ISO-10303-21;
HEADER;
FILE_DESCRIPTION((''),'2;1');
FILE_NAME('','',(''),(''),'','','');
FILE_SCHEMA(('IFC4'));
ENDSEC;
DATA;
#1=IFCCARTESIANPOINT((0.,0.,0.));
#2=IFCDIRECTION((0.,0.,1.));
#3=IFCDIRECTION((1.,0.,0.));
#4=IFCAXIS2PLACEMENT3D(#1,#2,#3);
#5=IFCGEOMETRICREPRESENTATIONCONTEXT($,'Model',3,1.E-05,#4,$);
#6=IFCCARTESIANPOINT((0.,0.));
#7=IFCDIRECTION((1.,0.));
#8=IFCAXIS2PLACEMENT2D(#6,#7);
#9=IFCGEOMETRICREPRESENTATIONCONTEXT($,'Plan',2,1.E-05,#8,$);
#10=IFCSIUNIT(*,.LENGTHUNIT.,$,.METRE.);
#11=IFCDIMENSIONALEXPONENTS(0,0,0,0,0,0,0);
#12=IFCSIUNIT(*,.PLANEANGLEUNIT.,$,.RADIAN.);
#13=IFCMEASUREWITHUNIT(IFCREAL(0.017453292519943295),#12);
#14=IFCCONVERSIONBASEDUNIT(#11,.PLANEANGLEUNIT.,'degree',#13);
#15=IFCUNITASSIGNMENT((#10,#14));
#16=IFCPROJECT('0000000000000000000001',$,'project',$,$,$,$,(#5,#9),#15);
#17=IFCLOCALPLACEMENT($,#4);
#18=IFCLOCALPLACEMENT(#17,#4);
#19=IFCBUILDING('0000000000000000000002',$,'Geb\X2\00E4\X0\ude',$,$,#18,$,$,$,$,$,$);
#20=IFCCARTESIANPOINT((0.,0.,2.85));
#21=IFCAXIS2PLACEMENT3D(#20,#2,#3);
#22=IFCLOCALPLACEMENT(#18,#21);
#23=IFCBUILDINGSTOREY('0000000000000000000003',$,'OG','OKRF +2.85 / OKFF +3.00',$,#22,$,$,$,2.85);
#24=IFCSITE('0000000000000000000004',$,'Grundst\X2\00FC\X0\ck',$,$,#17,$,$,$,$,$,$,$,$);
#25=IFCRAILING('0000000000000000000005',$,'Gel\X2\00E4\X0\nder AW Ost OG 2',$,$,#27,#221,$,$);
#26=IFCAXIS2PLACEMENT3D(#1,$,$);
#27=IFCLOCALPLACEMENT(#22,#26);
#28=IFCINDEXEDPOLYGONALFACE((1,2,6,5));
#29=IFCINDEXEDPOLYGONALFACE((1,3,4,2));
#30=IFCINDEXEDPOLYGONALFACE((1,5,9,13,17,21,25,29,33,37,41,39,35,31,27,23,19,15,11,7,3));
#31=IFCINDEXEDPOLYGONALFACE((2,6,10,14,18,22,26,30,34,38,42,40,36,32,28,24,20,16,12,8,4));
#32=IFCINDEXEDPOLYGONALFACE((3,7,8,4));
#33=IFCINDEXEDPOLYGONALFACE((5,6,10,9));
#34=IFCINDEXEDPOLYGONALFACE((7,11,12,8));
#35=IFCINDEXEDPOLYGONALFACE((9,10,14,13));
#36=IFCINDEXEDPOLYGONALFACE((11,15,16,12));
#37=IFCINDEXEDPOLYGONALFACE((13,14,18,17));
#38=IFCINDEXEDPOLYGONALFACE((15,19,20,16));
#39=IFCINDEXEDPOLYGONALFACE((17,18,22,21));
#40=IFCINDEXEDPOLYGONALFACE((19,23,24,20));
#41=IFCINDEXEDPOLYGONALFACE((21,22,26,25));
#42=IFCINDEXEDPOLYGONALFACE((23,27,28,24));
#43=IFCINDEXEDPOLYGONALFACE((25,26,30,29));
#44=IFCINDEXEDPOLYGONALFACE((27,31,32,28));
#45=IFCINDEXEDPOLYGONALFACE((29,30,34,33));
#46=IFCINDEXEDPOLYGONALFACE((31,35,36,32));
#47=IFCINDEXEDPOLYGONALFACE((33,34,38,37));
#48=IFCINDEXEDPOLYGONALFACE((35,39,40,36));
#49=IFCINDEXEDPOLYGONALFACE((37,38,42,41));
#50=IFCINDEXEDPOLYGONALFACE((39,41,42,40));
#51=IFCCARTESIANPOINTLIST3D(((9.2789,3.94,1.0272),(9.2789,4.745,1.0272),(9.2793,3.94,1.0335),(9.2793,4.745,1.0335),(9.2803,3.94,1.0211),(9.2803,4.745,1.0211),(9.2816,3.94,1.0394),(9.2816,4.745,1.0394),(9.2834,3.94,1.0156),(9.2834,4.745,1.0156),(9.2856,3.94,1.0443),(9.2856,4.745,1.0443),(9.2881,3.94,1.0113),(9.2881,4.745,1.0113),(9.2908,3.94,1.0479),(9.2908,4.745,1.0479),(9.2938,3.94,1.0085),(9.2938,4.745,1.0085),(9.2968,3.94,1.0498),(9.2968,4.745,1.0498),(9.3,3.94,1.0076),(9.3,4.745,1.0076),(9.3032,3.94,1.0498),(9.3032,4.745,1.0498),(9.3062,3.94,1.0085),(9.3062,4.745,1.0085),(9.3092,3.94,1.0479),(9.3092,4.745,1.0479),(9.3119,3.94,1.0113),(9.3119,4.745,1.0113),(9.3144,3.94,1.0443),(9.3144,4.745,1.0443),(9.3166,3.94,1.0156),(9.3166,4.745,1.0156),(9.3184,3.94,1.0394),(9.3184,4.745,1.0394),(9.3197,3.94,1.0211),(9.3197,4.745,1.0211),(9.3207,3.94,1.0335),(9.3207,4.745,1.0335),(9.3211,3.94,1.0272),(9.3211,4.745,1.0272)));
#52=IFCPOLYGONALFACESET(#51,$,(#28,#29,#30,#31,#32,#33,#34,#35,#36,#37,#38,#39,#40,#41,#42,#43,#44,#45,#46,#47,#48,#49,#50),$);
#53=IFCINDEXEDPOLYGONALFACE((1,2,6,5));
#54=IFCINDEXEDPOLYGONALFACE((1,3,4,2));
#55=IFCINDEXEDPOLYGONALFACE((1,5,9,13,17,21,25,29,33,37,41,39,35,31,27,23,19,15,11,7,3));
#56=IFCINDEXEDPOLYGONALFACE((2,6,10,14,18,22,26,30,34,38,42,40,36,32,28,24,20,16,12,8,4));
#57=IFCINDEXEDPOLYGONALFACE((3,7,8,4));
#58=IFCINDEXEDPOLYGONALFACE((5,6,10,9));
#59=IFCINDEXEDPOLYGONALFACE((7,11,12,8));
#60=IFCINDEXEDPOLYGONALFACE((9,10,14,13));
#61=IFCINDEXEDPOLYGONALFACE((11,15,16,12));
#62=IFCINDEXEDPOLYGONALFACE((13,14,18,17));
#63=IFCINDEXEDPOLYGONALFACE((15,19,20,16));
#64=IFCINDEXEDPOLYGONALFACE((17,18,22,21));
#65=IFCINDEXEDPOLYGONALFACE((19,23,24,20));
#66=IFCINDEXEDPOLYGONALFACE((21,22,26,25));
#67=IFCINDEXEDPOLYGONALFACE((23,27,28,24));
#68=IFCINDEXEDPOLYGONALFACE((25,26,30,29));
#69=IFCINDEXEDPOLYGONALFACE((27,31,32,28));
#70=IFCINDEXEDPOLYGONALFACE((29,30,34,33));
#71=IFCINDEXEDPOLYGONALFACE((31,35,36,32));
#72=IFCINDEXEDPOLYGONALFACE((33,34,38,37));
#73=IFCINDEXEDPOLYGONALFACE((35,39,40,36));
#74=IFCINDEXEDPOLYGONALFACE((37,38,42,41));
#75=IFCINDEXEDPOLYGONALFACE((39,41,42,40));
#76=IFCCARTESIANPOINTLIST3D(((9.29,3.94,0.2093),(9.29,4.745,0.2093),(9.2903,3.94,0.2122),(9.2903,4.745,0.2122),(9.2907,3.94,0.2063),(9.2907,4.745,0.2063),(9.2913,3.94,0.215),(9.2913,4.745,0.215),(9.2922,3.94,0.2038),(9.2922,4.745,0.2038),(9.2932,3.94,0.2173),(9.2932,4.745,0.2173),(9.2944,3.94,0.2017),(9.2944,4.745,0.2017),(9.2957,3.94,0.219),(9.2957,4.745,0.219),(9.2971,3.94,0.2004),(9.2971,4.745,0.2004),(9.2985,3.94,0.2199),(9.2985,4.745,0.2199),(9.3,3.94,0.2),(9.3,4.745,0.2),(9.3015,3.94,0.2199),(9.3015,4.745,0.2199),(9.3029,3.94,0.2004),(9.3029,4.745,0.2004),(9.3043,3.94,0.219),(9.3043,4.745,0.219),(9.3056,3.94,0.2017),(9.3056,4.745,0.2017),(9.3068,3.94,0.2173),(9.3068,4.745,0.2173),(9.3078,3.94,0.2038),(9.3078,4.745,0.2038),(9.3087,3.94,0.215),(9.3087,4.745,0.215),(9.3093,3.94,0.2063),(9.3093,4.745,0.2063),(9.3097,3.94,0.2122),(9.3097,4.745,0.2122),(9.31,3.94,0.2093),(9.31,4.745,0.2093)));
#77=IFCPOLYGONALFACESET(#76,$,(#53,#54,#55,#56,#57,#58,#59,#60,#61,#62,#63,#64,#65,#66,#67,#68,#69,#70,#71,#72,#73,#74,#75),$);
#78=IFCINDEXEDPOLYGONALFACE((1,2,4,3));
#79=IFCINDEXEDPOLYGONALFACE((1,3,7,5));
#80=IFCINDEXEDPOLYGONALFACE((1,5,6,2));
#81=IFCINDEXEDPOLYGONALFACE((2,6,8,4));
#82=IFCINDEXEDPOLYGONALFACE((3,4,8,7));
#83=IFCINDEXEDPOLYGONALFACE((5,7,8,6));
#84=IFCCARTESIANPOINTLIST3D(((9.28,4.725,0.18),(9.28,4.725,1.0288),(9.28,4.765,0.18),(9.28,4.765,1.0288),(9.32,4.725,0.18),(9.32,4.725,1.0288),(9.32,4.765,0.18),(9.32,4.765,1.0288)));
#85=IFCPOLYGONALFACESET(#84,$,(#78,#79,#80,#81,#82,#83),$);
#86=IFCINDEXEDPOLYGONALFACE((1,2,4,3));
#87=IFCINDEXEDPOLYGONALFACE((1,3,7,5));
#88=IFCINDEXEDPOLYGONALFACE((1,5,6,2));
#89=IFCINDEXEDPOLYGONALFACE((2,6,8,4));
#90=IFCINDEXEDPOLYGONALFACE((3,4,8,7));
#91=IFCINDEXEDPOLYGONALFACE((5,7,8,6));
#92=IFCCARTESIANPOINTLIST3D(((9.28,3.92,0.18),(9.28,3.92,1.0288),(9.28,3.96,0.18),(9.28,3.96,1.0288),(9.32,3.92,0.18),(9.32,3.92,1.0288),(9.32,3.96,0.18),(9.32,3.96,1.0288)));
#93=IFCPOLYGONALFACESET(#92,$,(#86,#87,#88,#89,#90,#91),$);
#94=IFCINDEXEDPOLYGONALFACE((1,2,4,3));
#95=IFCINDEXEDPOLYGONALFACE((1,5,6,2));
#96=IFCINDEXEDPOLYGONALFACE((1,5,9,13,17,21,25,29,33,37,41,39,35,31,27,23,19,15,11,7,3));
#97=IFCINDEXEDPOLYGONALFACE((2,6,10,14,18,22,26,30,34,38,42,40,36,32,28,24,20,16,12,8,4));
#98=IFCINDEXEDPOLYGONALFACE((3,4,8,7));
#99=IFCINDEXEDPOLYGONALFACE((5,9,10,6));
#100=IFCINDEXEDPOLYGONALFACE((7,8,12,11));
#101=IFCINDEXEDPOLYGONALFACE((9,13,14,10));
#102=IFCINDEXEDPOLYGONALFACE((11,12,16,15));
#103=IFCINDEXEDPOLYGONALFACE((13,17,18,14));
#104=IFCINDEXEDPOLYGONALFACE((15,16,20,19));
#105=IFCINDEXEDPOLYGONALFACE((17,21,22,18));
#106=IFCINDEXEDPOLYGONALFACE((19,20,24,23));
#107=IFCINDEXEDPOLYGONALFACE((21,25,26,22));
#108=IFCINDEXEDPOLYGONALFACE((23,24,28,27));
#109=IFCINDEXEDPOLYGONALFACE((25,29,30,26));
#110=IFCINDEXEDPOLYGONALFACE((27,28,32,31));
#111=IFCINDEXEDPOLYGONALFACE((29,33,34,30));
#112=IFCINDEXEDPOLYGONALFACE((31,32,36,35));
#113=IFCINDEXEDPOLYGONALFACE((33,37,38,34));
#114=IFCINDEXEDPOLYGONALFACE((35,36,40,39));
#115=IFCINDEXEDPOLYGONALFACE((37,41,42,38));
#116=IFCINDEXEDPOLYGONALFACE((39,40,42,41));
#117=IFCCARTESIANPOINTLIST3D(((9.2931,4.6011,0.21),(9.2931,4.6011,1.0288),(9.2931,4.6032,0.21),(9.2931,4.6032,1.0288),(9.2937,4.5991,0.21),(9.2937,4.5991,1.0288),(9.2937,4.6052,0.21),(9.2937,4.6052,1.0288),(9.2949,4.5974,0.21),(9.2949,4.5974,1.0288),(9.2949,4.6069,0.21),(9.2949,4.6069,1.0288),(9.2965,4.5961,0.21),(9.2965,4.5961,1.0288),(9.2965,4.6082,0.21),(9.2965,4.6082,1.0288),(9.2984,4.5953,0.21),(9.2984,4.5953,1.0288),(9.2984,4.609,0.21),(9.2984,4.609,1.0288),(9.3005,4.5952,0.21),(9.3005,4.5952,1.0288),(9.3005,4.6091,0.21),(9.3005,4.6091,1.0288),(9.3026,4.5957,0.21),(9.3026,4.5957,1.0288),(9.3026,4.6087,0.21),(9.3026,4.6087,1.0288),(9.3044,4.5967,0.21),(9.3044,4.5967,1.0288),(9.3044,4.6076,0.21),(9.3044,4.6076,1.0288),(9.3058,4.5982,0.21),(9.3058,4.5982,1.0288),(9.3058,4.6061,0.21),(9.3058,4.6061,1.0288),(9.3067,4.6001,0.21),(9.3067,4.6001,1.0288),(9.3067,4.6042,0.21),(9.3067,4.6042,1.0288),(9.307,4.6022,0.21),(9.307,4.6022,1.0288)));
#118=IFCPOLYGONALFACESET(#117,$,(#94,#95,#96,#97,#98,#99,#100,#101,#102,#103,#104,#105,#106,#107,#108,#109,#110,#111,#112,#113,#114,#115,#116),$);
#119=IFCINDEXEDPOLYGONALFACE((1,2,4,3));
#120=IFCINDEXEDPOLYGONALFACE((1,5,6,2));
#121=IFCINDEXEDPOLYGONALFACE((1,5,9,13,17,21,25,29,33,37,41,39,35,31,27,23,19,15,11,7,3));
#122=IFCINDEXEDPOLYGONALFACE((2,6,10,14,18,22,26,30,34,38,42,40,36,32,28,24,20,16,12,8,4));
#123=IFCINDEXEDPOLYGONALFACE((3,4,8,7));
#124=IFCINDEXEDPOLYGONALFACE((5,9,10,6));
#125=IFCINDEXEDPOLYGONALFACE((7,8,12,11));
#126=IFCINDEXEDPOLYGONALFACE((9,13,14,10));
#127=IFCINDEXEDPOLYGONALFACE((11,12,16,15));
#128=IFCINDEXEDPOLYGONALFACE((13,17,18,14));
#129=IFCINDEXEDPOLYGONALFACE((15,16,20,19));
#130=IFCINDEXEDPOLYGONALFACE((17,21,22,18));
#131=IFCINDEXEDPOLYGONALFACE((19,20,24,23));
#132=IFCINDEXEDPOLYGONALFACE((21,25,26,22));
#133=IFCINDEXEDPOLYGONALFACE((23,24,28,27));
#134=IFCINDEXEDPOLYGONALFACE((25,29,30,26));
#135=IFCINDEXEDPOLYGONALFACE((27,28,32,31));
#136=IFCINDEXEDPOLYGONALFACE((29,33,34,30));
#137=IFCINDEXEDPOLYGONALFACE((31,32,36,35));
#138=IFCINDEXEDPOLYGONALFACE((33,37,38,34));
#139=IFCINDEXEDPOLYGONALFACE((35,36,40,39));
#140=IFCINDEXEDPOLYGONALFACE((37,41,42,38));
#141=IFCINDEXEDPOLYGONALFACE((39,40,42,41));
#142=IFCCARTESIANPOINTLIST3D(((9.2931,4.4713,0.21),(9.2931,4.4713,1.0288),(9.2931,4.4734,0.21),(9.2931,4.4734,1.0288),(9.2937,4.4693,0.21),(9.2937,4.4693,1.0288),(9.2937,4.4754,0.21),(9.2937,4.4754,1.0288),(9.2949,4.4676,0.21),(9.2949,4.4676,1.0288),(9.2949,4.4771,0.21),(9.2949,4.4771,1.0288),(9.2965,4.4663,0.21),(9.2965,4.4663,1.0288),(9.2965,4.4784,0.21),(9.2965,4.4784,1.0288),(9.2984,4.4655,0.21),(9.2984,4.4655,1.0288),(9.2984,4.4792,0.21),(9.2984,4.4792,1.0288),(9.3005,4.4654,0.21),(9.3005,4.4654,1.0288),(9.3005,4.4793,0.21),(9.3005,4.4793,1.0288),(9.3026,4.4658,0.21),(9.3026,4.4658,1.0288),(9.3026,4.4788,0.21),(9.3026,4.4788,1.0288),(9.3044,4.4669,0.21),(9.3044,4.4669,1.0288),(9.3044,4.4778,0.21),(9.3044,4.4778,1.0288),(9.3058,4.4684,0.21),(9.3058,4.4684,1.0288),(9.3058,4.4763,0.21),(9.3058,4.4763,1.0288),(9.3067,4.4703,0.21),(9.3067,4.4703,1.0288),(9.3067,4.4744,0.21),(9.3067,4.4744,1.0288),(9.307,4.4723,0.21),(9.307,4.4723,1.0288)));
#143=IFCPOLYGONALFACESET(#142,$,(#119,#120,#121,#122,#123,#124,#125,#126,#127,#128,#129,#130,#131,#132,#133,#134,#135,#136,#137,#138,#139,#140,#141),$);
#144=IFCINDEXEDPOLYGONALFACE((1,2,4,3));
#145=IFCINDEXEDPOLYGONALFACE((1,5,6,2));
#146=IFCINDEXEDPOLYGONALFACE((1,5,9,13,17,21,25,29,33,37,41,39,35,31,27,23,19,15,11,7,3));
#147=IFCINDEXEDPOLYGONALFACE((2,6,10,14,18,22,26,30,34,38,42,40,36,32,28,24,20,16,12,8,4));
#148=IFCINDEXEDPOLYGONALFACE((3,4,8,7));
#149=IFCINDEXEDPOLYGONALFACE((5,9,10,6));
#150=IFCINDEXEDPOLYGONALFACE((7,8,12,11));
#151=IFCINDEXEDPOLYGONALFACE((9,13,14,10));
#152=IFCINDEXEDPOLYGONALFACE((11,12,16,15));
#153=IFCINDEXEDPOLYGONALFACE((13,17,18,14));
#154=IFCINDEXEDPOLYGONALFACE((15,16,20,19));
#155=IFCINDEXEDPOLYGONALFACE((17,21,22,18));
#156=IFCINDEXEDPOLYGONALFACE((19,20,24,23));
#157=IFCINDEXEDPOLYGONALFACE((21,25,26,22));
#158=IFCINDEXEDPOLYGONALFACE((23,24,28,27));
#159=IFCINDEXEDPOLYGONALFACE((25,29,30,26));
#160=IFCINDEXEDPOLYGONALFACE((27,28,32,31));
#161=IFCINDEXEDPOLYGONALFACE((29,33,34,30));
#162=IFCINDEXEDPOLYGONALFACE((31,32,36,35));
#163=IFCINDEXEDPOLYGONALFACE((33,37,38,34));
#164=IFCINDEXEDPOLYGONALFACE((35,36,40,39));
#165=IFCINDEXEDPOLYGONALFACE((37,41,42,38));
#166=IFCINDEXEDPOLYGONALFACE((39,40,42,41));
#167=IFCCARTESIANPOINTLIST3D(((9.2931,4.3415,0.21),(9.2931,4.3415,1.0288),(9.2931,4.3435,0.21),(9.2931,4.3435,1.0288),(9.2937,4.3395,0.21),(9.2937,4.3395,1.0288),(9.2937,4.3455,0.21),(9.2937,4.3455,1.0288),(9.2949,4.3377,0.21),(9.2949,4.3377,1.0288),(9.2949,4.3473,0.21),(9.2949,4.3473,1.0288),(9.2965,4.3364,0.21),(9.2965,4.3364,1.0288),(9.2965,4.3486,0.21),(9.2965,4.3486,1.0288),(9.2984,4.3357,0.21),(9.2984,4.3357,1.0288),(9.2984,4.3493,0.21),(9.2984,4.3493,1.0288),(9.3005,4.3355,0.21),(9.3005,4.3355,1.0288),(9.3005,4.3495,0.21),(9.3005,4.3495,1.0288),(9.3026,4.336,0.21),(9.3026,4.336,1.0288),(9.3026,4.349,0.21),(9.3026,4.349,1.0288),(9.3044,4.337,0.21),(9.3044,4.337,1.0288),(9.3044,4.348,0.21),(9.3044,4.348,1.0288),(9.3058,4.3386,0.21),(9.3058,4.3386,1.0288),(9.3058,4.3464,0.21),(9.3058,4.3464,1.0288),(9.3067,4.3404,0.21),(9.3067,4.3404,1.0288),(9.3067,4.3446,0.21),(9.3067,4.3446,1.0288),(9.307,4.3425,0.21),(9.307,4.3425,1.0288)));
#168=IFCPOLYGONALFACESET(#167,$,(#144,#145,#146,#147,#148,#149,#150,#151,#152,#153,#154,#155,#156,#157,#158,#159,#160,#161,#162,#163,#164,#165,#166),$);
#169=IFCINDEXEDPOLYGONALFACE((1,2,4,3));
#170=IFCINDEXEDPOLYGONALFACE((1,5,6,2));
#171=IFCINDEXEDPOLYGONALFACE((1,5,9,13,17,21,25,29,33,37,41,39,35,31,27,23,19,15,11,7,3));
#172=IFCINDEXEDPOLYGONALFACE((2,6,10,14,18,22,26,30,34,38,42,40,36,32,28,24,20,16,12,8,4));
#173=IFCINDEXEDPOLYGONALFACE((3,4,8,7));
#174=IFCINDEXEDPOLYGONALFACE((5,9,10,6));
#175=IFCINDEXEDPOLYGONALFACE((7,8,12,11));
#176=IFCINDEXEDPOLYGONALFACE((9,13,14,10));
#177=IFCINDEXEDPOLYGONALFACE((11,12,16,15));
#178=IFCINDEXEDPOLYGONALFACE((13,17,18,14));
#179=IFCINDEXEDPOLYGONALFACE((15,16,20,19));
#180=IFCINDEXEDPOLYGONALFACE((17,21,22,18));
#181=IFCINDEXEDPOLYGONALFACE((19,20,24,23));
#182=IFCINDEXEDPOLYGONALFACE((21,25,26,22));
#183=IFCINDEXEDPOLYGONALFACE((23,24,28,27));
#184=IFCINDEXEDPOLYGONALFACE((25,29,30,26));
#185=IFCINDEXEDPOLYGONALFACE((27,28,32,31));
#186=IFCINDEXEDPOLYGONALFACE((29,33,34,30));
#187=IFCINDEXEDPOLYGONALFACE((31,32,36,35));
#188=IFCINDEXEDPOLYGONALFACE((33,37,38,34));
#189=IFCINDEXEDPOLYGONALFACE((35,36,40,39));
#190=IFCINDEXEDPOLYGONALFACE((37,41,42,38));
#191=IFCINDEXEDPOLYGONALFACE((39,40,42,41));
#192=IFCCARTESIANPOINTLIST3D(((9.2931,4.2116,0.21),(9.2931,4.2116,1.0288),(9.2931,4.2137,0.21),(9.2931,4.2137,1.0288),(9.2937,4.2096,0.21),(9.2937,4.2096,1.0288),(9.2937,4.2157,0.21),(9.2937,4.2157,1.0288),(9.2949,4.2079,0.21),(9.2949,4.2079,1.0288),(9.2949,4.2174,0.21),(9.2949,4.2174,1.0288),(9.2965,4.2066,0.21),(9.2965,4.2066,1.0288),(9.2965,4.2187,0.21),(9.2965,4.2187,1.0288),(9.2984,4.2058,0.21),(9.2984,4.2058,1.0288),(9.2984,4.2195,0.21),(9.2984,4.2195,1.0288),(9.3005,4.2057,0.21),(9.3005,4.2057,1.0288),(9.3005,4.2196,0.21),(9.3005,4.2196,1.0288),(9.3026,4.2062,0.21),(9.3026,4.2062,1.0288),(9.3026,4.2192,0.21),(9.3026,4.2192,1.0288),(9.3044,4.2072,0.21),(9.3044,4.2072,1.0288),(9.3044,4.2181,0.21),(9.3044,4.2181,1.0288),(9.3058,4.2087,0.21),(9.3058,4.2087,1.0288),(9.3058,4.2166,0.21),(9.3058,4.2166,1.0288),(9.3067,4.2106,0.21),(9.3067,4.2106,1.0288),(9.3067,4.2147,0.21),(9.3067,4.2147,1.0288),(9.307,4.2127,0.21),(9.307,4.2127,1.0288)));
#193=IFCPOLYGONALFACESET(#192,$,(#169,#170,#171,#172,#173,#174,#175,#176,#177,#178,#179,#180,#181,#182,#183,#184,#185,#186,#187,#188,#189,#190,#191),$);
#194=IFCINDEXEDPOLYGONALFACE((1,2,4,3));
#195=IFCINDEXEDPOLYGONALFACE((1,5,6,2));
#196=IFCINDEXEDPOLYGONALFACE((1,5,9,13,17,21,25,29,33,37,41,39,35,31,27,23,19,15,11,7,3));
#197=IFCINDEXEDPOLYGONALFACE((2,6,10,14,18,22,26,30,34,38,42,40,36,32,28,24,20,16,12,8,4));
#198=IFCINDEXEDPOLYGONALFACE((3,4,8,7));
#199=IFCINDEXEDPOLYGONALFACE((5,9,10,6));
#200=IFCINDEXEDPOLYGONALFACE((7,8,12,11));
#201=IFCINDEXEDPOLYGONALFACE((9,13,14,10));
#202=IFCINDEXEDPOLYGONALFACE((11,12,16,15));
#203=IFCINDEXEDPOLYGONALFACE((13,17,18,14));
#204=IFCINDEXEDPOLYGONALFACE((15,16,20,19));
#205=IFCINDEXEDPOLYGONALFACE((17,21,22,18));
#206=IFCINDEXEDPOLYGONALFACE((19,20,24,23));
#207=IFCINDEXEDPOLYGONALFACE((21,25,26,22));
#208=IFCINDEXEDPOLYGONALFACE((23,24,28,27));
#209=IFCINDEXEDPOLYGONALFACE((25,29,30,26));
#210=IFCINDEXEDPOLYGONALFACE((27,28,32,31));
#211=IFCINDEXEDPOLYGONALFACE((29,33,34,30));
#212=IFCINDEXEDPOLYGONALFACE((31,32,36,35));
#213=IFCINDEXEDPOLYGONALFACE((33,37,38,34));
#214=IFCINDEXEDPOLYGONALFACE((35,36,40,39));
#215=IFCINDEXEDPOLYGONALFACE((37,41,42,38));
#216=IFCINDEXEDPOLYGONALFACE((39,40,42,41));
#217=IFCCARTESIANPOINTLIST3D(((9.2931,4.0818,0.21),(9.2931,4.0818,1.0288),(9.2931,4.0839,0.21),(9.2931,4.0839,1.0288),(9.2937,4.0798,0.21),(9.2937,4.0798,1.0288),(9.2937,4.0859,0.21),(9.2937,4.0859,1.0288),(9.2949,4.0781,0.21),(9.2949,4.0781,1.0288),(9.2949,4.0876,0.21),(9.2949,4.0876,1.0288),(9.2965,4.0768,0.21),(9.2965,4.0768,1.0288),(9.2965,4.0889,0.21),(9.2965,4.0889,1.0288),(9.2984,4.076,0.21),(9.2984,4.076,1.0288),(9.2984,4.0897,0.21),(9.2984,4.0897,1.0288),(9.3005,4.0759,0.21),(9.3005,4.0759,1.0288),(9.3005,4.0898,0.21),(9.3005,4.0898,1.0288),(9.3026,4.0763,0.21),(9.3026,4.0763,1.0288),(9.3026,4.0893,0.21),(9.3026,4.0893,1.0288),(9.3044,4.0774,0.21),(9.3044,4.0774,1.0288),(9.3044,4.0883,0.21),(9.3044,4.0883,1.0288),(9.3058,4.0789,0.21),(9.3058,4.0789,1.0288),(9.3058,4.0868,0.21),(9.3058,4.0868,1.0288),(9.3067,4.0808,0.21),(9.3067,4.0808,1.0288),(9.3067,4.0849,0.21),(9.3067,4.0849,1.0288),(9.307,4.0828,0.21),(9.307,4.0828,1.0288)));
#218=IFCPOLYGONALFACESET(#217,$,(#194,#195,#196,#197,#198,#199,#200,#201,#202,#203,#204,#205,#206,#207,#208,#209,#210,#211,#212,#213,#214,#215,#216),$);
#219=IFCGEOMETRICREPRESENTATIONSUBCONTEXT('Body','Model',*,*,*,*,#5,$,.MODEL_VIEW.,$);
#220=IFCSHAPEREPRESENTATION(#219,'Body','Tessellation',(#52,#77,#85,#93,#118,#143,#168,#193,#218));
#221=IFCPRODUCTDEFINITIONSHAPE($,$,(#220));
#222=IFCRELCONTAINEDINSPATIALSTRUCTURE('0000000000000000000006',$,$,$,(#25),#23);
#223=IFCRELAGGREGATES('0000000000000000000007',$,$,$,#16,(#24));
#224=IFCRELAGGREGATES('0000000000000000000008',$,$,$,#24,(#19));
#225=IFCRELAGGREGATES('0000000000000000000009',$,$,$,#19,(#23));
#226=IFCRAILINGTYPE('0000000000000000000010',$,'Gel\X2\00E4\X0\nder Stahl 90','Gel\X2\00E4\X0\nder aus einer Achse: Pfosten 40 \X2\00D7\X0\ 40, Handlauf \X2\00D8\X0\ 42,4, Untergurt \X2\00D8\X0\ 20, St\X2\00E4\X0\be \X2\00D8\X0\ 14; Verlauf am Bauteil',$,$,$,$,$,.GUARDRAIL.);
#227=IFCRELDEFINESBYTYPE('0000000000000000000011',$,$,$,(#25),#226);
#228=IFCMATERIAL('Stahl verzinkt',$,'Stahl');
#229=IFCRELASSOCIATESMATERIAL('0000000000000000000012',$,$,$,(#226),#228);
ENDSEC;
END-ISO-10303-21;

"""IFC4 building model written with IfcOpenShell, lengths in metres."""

from ifc_helpers import new_model, entity, si_unit, converted_unit, frame, origin_with_axes, origin_2d_with_axis, place, context, subcontext, project, spatial, polyline, outline, extrude, material, type_object, element, save


model = new_model("IFC4")

# Units and contexts
model_context = context("Model", 3, precision=1e-05, world=origin_with_axes())
plan_context = context("Plan", 2, precision=1e-05, world=origin_2d_with_axis())
body_context = subcontext(model_context, "Body", "Model", "MODEL_VIEW")
ifc_project = project(units=[si_unit("LENGTHUNIT", "METRE"), converted_unit("PLANEANGLEUNIT", "degree", entity("IfcReal", 0.017453292519943295), si_unit("PLANEANGLEUNIT", "RADIAN"), dimensions=[0, 0, 0, 0, 0, 0, 0])], contexts=[model_context, plan_context])

# Site, building, storey
site_placement = place(None, origin_with_axes())
site = spatial("IfcSite", under=ifc_project, at=site_placement, Name="Grundstück")
building_placement = place(site_placement, origin_with_axes())
building = spatial("IfcBuilding", under=site, at=building_placement, Name="Gebäude")
storey_placement = place(building_placement, frame((0.0, 0.0, 2.85), z_axis=(0.0, 0.0, 1.0), x_axis=(1.0, 0.0, 0.0)))
storey = spatial("IfcBuildingStorey", under=building, at=storey_placement, Name="OG", Description="OKRF +2.85 / OKFF +3.00", Elevation=2.85)

# Railing
ifc_material_1 = material(Name="Stahl verzinkt", Category="Stahl")
railing_type = type_object("IfcRailingType", Name="Geländer Stahl 90", Description="Geländer aus einer Achse: Pfosten 40 × 40, Handlauf Ø 42,4, Untergurt Ø 20, Stäbe Ø 14; Verlauf am Bauteil", PredefinedType="GUARDRAIL", material=ifc_material_1)
railing_1_placement = place(storey_placement, frame((0.0, 0.0, -2.85), z_axis=(0.0, 0.0, 1.0), x_axis=(1.0, 0.0, 0.0)))
element("IfcRailing", 1, at=railing_1_placement, inside=storey, type_object=railing_type, Name="Geländer AW Ost OG 2", context=body_context, shape_type="SolidModel", body=[
    entity("IfcSweptDiskSolid", entity("IfcPolyline", [entity("IfcCartesianPoint", [9.3, 4.745, 3.8788]), entity("IfcCartesianPoint", [9.3, 3.94, 3.8788])]), 0.0212),
    entity("IfcSweptDiskSolid", entity("IfcPolyline", [entity("IfcCartesianPoint", [9.3, 4.745, 3.06]), entity("IfcCartesianPoint", [9.3, 3.94, 3.06])]), 0.01),
    extrude(outline(polyline([(9.28, 4.765), (9.28, 4.725), (9.32, 4.725), (9.32, 4.765), (9.28, 4.765)])), frame((0.0, 0.0, 3.03), z_axis=(0.0, 0.0, 1.0), x_axis=(1.0, 0.0, 0.0)), (0.0, 0.0, 1.0), 0.8488),
    extrude(outline(polyline([(9.28, 3.96), (9.28, 3.92), (9.32, 3.92), (9.32, 3.96), (9.28, 3.96)])), frame((0.0, 0.0, 3.03), z_axis=(0.0, 0.0, 1.0), x_axis=(1.0, 0.0, 0.0)), (0.0, 0.0, 1.0), 0.8488),
    entity("IfcSweptDiskSolid", entity("IfcPolyline", [entity("IfcCartesianPoint", [9.3, 4.6022, 3.06]), entity("IfcCartesianPoint", [9.3, 4.6022, 3.8788])]), 0.007),
    entity("IfcSweptDiskSolid", entity("IfcPolyline", [entity("IfcCartesianPoint", [9.3, 4.4723, 3.06]), entity("IfcCartesianPoint", [9.3, 4.4723, 3.8788])]), 0.007),
    entity("IfcSweptDiskSolid", entity("IfcPolyline", [entity("IfcCartesianPoint", [9.3, 4.3425, 3.06]), entity("IfcCartesianPoint", [9.3, 4.3425, 3.8788])]), 0.007),
    entity("IfcSweptDiskSolid", entity("IfcPolyline", [entity("IfcCartesianPoint", [9.3, 4.2127, 3.06]), entity("IfcCartesianPoint", [9.3, 4.2127, 3.8788])]), 0.007),
    entity("IfcSweptDiskSolid", entity("IfcPolyline", [entity("IfcCartesianPoint", [9.3, 4.0828, 3.06]), entity("IfcCartesianPoint", [9.3, 4.0828, 3.8788])]), 0.007),
])

save(model, "model.ifc")
